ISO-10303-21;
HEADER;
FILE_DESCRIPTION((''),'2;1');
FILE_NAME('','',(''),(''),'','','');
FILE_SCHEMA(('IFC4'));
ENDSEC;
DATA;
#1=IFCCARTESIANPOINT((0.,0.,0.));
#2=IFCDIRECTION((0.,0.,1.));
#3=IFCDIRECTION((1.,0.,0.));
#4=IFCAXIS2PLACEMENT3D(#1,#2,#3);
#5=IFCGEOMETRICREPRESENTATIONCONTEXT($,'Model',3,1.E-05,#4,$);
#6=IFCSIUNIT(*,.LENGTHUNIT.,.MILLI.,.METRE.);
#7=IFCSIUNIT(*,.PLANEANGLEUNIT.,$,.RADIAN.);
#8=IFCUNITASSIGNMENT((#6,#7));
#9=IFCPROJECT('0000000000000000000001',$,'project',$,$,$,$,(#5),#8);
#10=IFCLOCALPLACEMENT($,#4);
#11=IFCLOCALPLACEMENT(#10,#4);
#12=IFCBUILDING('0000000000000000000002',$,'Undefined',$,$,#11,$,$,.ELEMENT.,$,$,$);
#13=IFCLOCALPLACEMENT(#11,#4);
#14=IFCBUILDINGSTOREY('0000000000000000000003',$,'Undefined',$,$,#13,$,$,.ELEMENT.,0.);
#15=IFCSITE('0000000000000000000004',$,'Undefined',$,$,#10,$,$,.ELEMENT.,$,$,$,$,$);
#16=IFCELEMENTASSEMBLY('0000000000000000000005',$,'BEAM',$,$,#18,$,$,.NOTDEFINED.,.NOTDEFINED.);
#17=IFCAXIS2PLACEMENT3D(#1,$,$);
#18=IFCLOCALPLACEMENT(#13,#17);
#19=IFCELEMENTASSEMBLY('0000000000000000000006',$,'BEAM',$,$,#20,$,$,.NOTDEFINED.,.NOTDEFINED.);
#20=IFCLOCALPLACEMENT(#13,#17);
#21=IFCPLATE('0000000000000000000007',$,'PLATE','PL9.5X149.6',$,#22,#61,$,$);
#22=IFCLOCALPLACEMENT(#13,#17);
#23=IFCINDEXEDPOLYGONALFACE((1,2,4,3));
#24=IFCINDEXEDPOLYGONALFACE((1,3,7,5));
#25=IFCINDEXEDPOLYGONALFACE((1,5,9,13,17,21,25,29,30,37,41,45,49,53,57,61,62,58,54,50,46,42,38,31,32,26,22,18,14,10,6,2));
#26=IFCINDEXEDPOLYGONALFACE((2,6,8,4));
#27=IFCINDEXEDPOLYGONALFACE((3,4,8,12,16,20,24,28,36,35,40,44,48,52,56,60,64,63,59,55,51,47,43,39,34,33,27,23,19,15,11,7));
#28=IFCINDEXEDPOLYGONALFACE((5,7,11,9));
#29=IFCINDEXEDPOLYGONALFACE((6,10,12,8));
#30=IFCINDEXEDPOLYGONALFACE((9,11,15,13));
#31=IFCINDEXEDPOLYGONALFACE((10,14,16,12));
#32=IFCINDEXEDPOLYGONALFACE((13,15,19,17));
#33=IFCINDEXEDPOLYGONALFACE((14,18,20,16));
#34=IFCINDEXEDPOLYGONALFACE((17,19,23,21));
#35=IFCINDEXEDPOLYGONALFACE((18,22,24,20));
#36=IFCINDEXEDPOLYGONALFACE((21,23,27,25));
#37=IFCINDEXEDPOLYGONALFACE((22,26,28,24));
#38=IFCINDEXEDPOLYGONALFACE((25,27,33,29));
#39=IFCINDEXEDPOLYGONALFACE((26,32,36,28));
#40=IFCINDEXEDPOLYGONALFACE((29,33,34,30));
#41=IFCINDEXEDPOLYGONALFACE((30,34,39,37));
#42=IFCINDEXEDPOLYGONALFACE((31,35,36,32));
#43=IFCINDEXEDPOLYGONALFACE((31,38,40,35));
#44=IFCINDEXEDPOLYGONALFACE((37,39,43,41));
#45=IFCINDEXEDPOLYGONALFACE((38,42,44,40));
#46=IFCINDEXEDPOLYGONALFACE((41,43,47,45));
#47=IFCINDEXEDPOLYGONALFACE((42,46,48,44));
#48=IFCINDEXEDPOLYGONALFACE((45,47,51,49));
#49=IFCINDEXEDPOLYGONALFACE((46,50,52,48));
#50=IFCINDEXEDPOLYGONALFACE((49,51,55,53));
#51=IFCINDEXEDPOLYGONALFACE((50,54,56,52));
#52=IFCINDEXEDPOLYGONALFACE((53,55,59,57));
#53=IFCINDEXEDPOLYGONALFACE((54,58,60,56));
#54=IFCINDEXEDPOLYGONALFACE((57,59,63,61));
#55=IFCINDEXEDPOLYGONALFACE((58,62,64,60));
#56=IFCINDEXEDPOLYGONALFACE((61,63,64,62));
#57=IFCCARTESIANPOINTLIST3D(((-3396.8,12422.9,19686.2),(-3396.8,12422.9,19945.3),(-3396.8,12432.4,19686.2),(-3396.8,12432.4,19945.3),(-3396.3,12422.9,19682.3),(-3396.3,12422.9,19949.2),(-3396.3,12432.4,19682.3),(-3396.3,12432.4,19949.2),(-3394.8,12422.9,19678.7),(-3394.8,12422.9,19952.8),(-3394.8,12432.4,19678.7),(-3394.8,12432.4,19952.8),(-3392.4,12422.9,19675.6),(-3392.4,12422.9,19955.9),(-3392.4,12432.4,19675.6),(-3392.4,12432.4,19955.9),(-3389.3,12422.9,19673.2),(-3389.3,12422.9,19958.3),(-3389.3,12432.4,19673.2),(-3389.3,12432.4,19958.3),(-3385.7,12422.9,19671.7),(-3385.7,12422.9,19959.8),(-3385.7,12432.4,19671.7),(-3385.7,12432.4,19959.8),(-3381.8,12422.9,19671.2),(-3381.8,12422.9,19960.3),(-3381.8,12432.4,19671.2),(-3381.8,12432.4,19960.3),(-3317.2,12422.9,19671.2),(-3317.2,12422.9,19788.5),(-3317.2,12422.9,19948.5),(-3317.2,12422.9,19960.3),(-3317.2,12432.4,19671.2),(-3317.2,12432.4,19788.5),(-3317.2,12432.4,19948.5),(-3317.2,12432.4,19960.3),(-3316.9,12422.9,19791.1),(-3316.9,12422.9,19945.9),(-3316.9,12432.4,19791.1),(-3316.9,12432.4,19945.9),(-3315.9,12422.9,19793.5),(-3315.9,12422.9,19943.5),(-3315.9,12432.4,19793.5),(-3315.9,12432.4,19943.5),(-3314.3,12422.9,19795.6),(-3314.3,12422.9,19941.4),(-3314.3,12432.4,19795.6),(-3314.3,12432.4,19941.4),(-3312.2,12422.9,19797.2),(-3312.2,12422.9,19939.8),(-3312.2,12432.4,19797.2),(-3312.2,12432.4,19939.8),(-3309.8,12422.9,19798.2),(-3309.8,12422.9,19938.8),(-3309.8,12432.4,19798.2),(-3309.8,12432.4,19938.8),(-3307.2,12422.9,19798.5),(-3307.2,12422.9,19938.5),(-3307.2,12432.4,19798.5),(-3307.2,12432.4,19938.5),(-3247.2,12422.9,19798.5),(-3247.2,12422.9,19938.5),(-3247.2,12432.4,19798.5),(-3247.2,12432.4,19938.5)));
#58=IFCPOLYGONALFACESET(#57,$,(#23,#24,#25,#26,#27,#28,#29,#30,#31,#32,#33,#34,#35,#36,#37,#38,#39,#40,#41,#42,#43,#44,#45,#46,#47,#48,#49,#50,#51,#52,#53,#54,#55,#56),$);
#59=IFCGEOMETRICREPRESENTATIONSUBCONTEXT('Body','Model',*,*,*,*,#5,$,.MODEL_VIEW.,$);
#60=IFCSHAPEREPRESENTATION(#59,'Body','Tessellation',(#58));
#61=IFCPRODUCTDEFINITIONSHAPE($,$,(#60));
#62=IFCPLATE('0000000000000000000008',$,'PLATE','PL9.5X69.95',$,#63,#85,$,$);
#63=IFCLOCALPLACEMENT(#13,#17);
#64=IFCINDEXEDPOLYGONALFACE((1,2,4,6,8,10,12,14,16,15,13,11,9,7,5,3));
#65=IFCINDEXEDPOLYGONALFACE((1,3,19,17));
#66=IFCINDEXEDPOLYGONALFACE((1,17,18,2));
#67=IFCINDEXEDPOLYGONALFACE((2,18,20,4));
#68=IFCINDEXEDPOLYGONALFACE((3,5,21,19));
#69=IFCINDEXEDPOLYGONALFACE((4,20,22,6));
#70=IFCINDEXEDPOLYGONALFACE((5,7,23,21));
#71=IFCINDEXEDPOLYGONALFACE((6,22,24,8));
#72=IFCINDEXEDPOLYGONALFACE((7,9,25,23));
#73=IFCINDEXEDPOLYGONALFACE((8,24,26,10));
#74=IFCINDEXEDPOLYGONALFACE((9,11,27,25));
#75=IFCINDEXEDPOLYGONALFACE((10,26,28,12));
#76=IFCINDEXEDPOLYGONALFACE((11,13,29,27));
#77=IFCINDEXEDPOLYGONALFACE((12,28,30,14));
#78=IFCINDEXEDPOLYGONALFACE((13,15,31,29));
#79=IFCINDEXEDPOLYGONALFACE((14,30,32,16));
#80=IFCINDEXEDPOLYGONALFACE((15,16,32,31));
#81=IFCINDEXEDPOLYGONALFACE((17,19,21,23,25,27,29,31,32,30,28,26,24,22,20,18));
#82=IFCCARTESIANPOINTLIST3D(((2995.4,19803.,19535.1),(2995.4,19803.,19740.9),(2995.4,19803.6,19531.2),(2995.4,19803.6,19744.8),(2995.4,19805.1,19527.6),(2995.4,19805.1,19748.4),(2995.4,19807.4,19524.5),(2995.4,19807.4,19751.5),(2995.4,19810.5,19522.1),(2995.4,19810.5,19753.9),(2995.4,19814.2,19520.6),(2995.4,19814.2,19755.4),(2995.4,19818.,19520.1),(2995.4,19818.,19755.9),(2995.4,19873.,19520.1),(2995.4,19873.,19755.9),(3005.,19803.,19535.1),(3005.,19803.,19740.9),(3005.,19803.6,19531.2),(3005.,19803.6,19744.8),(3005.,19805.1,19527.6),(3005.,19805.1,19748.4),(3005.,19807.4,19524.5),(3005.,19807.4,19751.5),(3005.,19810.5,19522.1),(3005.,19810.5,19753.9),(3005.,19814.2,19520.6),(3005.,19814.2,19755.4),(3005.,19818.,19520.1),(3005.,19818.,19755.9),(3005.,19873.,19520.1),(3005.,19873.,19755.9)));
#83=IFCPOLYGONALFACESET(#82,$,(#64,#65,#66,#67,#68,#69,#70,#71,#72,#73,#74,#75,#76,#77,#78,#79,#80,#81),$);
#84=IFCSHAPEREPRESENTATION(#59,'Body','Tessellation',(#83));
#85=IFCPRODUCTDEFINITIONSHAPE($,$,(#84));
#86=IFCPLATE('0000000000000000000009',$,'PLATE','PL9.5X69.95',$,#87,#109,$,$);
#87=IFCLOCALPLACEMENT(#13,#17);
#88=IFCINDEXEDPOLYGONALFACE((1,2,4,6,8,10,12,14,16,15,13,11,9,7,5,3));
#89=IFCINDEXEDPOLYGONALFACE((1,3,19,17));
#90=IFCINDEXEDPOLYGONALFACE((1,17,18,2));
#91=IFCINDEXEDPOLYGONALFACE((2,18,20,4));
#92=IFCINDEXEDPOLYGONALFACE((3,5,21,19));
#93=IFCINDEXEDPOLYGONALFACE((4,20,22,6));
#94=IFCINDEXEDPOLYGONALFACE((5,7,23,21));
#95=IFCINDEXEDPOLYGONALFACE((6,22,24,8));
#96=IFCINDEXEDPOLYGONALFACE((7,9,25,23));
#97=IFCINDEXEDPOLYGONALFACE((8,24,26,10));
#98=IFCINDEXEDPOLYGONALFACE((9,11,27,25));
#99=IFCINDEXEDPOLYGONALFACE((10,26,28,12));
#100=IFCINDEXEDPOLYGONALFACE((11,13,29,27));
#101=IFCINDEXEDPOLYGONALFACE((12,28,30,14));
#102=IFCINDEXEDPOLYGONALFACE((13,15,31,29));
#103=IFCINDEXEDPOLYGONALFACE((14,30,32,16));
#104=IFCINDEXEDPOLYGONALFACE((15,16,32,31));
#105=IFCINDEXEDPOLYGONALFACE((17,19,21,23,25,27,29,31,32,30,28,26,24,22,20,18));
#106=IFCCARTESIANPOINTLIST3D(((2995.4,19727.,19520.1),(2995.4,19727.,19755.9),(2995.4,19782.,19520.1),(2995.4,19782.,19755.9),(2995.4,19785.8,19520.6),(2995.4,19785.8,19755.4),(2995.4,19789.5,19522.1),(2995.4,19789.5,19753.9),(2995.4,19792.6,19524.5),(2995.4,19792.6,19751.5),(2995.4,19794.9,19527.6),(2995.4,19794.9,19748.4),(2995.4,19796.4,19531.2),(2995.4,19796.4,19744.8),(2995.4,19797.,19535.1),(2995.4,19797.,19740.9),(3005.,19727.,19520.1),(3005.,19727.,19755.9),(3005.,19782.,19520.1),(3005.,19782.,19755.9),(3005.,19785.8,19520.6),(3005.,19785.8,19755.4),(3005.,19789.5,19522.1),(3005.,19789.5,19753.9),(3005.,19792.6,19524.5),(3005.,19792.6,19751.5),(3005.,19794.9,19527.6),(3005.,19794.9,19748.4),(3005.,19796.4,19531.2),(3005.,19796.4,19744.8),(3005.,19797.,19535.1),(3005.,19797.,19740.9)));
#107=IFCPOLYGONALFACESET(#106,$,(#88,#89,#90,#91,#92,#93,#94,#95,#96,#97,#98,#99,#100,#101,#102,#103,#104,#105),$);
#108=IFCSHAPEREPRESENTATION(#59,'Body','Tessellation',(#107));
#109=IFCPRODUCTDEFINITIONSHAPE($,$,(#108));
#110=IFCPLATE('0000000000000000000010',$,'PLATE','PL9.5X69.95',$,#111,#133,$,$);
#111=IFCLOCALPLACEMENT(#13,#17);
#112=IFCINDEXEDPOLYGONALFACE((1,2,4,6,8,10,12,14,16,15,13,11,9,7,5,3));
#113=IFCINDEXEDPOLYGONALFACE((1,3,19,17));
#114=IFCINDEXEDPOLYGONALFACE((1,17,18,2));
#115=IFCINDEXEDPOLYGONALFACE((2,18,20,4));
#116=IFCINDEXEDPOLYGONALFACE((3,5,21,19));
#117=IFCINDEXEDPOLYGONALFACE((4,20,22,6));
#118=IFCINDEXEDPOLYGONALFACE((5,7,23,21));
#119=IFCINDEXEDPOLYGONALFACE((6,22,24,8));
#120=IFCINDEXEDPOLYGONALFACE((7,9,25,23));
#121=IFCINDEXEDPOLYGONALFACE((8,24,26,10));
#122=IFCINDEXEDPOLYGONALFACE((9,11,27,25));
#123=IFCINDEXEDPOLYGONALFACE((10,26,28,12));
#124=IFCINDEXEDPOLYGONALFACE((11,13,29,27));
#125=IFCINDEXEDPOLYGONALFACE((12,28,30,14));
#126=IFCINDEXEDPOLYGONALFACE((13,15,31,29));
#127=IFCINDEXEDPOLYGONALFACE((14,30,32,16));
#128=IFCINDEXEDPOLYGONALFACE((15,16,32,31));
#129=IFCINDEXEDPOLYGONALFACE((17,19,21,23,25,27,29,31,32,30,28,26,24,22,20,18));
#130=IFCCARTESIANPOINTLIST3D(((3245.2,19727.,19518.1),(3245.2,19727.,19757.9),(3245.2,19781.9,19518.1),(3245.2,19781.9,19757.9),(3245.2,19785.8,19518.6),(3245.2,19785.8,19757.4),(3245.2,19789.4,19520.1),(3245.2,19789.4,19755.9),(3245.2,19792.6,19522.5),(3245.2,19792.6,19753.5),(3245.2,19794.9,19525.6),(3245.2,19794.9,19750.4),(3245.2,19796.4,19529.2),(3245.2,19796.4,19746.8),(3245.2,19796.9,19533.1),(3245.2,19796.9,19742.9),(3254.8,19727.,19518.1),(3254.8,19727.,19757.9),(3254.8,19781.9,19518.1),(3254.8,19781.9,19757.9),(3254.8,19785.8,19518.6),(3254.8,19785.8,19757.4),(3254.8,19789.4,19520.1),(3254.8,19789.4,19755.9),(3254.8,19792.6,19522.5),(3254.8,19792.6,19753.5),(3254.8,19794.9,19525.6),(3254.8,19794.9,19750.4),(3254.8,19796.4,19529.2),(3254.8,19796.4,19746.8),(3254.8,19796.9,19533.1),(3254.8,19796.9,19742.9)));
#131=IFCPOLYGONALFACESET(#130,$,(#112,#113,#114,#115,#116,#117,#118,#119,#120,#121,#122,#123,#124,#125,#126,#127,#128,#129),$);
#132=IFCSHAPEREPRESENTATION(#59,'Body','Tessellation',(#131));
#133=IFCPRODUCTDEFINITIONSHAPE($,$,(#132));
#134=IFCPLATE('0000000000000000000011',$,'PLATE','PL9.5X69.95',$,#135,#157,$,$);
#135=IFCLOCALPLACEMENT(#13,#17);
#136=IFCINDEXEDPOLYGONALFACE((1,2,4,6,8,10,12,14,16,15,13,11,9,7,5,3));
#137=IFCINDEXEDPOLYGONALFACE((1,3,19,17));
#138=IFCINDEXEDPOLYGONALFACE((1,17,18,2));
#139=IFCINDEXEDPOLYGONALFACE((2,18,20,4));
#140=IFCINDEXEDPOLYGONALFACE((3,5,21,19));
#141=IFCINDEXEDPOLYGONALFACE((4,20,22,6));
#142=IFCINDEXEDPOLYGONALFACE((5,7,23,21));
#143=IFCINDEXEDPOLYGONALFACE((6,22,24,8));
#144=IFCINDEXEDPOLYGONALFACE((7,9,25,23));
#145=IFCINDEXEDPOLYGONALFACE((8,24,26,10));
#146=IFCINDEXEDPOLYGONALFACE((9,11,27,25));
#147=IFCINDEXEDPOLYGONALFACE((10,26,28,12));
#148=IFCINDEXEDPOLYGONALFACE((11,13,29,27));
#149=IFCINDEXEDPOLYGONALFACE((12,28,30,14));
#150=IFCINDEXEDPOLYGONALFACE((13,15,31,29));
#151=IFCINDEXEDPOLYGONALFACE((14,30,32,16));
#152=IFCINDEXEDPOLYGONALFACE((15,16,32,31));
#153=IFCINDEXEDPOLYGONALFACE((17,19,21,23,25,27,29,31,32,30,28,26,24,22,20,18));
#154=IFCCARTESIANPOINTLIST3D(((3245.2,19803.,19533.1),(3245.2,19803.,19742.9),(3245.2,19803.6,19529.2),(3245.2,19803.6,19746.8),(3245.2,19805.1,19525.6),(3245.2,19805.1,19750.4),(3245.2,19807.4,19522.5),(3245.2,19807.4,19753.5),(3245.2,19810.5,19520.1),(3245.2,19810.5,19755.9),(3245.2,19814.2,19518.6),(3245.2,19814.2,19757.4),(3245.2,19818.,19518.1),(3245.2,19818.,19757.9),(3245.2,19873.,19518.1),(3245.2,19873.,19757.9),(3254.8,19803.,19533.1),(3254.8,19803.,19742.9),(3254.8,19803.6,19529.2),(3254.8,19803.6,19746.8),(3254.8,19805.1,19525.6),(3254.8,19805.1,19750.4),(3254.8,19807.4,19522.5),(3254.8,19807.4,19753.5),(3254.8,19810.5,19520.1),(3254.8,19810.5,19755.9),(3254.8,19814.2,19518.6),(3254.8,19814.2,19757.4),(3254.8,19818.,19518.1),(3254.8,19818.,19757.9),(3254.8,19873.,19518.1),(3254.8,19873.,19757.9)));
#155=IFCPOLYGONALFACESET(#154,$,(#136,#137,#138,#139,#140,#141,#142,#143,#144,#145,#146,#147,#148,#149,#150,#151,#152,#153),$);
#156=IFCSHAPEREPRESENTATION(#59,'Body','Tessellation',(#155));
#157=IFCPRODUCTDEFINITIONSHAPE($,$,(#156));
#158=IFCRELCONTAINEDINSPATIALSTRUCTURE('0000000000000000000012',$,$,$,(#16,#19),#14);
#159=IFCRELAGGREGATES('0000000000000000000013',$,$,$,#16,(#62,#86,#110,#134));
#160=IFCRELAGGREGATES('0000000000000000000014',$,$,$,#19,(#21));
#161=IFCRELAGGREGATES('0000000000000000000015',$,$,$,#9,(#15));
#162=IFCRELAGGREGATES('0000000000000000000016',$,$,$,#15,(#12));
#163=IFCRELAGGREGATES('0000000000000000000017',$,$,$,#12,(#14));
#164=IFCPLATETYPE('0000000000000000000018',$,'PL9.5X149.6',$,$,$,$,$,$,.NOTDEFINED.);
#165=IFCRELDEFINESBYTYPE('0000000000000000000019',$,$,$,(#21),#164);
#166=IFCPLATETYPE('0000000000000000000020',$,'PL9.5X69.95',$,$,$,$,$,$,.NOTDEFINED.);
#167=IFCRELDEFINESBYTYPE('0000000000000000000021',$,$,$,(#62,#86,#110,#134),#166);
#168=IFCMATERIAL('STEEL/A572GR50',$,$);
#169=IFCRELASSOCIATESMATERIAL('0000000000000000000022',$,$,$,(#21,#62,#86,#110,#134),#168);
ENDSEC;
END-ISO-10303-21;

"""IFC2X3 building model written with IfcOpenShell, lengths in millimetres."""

from ifc_helpers import new_model, si_unit, frame, frame_2d, origin_with_axes, place, context, subcontext, project, spatial, polyline, circle_curve, parameter, trimmed, segment, composite_curve, outline, extrude, material, type_object, element, aggregate, save


model = new_model("IFC2X3")

# Units and contexts
model_context = context("Model", 3, precision=1e-05, world=origin_with_axes())
body_context = subcontext(model_context, "Body", "Model", "MODEL_VIEW")
ifc_project = project(units=[si_unit("LENGTHUNIT", "METRE", prefix="MILLI"), si_unit("PLANEANGLEUNIT", "RADIAN")], contexts=[model_context])

# Site, building, storey
site_placement = place(None, origin_with_axes())
site = spatial("IfcSite", under=ifc_project, at=site_placement, Name="Undefined", CompositionType="ELEMENT")
building_placement = place(site_placement, origin_with_axes())
building = spatial("IfcBuilding", under=site, at=building_placement, Name="Undefined", CompositionType="ELEMENT")
storey_placement = place(building_placement, origin_with_axes())
storey = spatial("IfcBuildingStorey", under=building, at=storey_placement, Name="Undefined", CompositionType="ELEMENT", Elevation=0.0)

# Element assembly
assembly_1_placement = place(storey_placement, origin_with_axes())
assembly_1 = element("IfcElementAssembly", 1, at=assembly_1_placement, inside=storey, Name="BEAM", AssemblyPlace="NOTDEFINED", PredefinedType="NOTDEFINED")
ifc_material_1 = material(Name="STEEL/A572GR50")

# Element assembly
assembly_2_placement = place(storey_placement, origin_with_axes())
assembly_2 = element("IfcElementAssembly", 2, at=assembly_2_placement, inside=storey, Name="BEAM", AssemblyPlace="NOTDEFINED", PredefinedType="NOTDEFINED")

# Shared definitions
plate_type_1 = type_object("IfcPlateType", Name="PL9.5X149.6", PredefinedType="NOTDEFINED")

# Plates
plate_1_placement = place(assembly_2_placement, frame((-3396.8, 12427.7, 19960.3), z_axis=(0.0, -1.0, 0.0), x_axis=(0.0, 0.0, -1.0)))
plate_1 = element("IfcPlate", 3, at=plate_1_placement, type_object=plate_type_1, material=ifc_material_1, Name="PLATE", Description="PL9.5X149.6", context=body_context, shape_type="SweptSolid", body=[
    extrude(outline(composite_curve([segment(trimmed(circle_curve(frame_2d((15.0, 15.0), x_axis=(-1.0, 0.0)), 15.0), [parameter(0.0)], [parameter(1.570796)], True, "PARAMETER"), True, "CONTINUOUS"), segment(polyline([(15.0, 0.0), (274.1, 0.0)]), True, "CONTINUOUS"), segment(trimmed(circle_curve(frame_2d((274.1, 15.0), x_axis=(0.0, -1.0)), 15.0), [parameter(0.0)], [parameter(1.570796)], True, "PARAMETER"), True, "CONTINUOUS"), segment(polyline([(289.1, 15.0), (289.1, 79.6), (171.8, 79.6)]), True, "CONTINUOUS"), segment(trimmed(circle_curve(frame_2d((171.8, 89.6), x_axis=(0.0, -1.0)), 10.0), [parameter(0.0)], [parameter(4.712389)], False, "PARAMETER"), True, "CONTINUOUS"), segment(polyline([(161.8, 89.6), (161.8, 149.6), (21.8, 149.6), (21.8, 89.6)]), True, "CONTINUOUS"), segment(trimmed(circle_curve(frame_2d((11.8, 89.6), x_axis=(1.0, 0.0)), 10.0), [parameter(0.0)], [parameter(4.712389)], False, "PARAMETER"), True, "CONTINUOUS"), segment(polyline([(11.8, 79.6), (0.0, 79.6), (0.0, 15.0)]), True, "CONTINUOUS")], self_intersect=True)), frame((0.0, 0.0, -4.8), z_axis=(0.0, 0.0, 1.0), x_axis=(1.0, 0.0, 0.0)), (0.0, 0.0, 1.0), 9.5),
])
plate_type_2 = type_object("IfcPlateType", Name="PL9.5X69.95", PredefinedType="NOTDEFINED")
plate_2_placement = place(assembly_1_placement, frame((3000.2, 19803.0, 19520.1), z_axis=(1.0, 0.0, 0.0), x_axis=(0.0, 1.0, 0.0)))
plate_2 = element("IfcPlate", 4, at=plate_2_placement, type_object=plate_type_2, material=ifc_material_1, Name="PLATE", Description="PL9.5X69.95", context=body_context, shape_type="SweptSolid", body=[
    extrude(outline(composite_curve([segment(trimmed(circle_curve(frame_2d((15.0, 15.0), x_axis=(-1.0, 0.0)), 15.0), [parameter(0.0)], [parameter(1.570796)], True, "PARAMETER"), True, "CONTINUOUS"), segment(polyline([(15.0, 0.0), (69.9, 0.0), (69.9, 235.8), (15.0, 235.8)]), True, "CONTINUOUS"), segment(trimmed(circle_curve(frame_2d((15.0, 220.8), x_axis=(0.0, 1.0)), 15.0), [parameter(0.0)], [parameter(1.570796)], True, "PARAMETER"), True, "CONTINUOUS"), segment(polyline([(0.0, 220.8), (0.0, 15.0)]), True, "CONTINUOUS")], self_intersect=True)), frame((0.0, 0.0, -4.8), z_axis=(0.0, 0.0, 1.0), x_axis=(1.0, 0.0, 0.0)), (0.0, 0.0, 1.0), 9.5),
])
plate_3_placement = place(assembly_1_placement, frame((3000.2, 19797.0, 19520.1), z_axis=(-1.0, 0.0, 0.0), x_axis=(0.0, -1.0, 0.0)))
plate_3 = element("IfcPlate", 5, at=plate_3_placement, type_object=plate_type_2, material=ifc_material_1, Name="PLATE", Description="PL9.5X69.95", context=body_context, shape_type="SweptSolid", body=[
    extrude(outline(composite_curve([segment(trimmed(circle_curve(frame_2d((15.0, 15.0), x_axis=(-1.0, 0.0)), 15.0), [parameter(0.0)], [parameter(1.570796)], True, "PARAMETER"), True, "CONTINUOUS"), segment(polyline([(15.0, 0.0), (69.9, 0.0), (69.9, 235.8), (15.0, 235.8)]), True, "CONTINUOUS"), segment(trimmed(circle_curve(frame_2d((15.0, 220.8), x_axis=(0.0, 1.0)), 15.0), [parameter(0.0)], [parameter(1.570796)], True, "PARAMETER"), True, "CONTINUOUS"), segment(polyline([(0.0, 220.8), (0.0, 15.0)]), True, "CONTINUOUS")], self_intersect=True)), frame((0.0, 0.0, -4.8), z_axis=(0.0, 0.0, 1.0), x_axis=(1.0, 0.0, 0.0)), (0.0, 0.0, 1.0), 9.5),
])
plate_4_placement = place(assembly_1_placement, frame((3250.0, 19727.0, 19518.1), z_axis=(1.0, 0.0, 0.0), x_axis=(0.0, 1.0, 0.0)))
plate_4 = element("IfcPlate", 6, at=plate_4_placement, type_object=plate_type_2, material=ifc_material_1, Name="PLATE", Description="PL9.5X69.95", context=body_context, shape_type="SweptSolid", body=[
    extrude(outline(composite_curve([segment(polyline([(0.0, 0.0), (54.9, 0.0)]), True, "CONTINUOUS"), segment(trimmed(circle_curve(frame_2d((54.9, 15.0), x_axis=(0.0, -1.0)), 15.0), [parameter(0.0)], [parameter(1.570796)], True, "PARAMETER"), True, "CONTINUOUS"), segment(polyline([(69.9, 15.0), (69.9, 224.8)]), True, "CONTINUOUS"), segment(trimmed(circle_curve(frame_2d((54.9, 224.8), x_axis=(1.0, 0.0)), 15.0), [parameter(0.0)], [parameter(1.570796)], True, "PARAMETER"), True, "CONTINUOUS"), segment(polyline([(54.9, 239.8), (0.0, 239.8), (0.0, 0.0)]), True, "CONTINUOUS")], self_intersect=True)), frame((0.0, 0.0, -4.8), z_axis=(0.0, 0.0, 1.0), x_axis=(1.0, 0.0, 0.0)), (0.0, 0.0, 1.0), 9.5),
])
plate_5_placement = place(assembly_1_placement, frame((3250.0, 19803.0, 19518.1), z_axis=(1.0, 0.0, 0.0), x_axis=(0.0, 1.0, 0.0)))
plate_5 = element("IfcPlate", 7, at=plate_5_placement, type_object=plate_type_2, material=ifc_material_1, Name="PLATE", Description="PL9.5X69.95", context=body_context, shape_type="SweptSolid", body=[
    extrude(outline(composite_curve([segment(trimmed(circle_curve(frame_2d((15.0, 15.0), x_axis=(-1.0, 0.0)), 15.0), [parameter(0.0)], [parameter(1.570796)], True, "PARAMETER"), True, "CONTINUOUS"), segment(polyline([(15.0, 0.0), (69.9, 0.0), (69.9, 239.8), (15.0, 239.8)]), True, "CONTINUOUS"), segment(trimmed(circle_curve(frame_2d((15.0, 224.8), x_axis=(0.0, 1.0)), 15.0), [parameter(0.0)], [parameter(1.570796)], True, "PARAMETER"), True, "CONTINUOUS"), segment(polyline([(0.0, 224.8), (0.0, 15.0)]), True, "CONTINUOUS")], self_intersect=True)), frame((0.0, 0.0, -4.8), z_axis=(0.0, 0.0, 1.0), x_axis=(1.0, 0.0, 0.0)), (0.0, 0.0, 1.0), 9.5),
])

aggregate(assembly_1, [plate_2, plate_3, plate_4, plate_5])
aggregate(assembly_2, [plate_1])

save(model, "model.ifc")
